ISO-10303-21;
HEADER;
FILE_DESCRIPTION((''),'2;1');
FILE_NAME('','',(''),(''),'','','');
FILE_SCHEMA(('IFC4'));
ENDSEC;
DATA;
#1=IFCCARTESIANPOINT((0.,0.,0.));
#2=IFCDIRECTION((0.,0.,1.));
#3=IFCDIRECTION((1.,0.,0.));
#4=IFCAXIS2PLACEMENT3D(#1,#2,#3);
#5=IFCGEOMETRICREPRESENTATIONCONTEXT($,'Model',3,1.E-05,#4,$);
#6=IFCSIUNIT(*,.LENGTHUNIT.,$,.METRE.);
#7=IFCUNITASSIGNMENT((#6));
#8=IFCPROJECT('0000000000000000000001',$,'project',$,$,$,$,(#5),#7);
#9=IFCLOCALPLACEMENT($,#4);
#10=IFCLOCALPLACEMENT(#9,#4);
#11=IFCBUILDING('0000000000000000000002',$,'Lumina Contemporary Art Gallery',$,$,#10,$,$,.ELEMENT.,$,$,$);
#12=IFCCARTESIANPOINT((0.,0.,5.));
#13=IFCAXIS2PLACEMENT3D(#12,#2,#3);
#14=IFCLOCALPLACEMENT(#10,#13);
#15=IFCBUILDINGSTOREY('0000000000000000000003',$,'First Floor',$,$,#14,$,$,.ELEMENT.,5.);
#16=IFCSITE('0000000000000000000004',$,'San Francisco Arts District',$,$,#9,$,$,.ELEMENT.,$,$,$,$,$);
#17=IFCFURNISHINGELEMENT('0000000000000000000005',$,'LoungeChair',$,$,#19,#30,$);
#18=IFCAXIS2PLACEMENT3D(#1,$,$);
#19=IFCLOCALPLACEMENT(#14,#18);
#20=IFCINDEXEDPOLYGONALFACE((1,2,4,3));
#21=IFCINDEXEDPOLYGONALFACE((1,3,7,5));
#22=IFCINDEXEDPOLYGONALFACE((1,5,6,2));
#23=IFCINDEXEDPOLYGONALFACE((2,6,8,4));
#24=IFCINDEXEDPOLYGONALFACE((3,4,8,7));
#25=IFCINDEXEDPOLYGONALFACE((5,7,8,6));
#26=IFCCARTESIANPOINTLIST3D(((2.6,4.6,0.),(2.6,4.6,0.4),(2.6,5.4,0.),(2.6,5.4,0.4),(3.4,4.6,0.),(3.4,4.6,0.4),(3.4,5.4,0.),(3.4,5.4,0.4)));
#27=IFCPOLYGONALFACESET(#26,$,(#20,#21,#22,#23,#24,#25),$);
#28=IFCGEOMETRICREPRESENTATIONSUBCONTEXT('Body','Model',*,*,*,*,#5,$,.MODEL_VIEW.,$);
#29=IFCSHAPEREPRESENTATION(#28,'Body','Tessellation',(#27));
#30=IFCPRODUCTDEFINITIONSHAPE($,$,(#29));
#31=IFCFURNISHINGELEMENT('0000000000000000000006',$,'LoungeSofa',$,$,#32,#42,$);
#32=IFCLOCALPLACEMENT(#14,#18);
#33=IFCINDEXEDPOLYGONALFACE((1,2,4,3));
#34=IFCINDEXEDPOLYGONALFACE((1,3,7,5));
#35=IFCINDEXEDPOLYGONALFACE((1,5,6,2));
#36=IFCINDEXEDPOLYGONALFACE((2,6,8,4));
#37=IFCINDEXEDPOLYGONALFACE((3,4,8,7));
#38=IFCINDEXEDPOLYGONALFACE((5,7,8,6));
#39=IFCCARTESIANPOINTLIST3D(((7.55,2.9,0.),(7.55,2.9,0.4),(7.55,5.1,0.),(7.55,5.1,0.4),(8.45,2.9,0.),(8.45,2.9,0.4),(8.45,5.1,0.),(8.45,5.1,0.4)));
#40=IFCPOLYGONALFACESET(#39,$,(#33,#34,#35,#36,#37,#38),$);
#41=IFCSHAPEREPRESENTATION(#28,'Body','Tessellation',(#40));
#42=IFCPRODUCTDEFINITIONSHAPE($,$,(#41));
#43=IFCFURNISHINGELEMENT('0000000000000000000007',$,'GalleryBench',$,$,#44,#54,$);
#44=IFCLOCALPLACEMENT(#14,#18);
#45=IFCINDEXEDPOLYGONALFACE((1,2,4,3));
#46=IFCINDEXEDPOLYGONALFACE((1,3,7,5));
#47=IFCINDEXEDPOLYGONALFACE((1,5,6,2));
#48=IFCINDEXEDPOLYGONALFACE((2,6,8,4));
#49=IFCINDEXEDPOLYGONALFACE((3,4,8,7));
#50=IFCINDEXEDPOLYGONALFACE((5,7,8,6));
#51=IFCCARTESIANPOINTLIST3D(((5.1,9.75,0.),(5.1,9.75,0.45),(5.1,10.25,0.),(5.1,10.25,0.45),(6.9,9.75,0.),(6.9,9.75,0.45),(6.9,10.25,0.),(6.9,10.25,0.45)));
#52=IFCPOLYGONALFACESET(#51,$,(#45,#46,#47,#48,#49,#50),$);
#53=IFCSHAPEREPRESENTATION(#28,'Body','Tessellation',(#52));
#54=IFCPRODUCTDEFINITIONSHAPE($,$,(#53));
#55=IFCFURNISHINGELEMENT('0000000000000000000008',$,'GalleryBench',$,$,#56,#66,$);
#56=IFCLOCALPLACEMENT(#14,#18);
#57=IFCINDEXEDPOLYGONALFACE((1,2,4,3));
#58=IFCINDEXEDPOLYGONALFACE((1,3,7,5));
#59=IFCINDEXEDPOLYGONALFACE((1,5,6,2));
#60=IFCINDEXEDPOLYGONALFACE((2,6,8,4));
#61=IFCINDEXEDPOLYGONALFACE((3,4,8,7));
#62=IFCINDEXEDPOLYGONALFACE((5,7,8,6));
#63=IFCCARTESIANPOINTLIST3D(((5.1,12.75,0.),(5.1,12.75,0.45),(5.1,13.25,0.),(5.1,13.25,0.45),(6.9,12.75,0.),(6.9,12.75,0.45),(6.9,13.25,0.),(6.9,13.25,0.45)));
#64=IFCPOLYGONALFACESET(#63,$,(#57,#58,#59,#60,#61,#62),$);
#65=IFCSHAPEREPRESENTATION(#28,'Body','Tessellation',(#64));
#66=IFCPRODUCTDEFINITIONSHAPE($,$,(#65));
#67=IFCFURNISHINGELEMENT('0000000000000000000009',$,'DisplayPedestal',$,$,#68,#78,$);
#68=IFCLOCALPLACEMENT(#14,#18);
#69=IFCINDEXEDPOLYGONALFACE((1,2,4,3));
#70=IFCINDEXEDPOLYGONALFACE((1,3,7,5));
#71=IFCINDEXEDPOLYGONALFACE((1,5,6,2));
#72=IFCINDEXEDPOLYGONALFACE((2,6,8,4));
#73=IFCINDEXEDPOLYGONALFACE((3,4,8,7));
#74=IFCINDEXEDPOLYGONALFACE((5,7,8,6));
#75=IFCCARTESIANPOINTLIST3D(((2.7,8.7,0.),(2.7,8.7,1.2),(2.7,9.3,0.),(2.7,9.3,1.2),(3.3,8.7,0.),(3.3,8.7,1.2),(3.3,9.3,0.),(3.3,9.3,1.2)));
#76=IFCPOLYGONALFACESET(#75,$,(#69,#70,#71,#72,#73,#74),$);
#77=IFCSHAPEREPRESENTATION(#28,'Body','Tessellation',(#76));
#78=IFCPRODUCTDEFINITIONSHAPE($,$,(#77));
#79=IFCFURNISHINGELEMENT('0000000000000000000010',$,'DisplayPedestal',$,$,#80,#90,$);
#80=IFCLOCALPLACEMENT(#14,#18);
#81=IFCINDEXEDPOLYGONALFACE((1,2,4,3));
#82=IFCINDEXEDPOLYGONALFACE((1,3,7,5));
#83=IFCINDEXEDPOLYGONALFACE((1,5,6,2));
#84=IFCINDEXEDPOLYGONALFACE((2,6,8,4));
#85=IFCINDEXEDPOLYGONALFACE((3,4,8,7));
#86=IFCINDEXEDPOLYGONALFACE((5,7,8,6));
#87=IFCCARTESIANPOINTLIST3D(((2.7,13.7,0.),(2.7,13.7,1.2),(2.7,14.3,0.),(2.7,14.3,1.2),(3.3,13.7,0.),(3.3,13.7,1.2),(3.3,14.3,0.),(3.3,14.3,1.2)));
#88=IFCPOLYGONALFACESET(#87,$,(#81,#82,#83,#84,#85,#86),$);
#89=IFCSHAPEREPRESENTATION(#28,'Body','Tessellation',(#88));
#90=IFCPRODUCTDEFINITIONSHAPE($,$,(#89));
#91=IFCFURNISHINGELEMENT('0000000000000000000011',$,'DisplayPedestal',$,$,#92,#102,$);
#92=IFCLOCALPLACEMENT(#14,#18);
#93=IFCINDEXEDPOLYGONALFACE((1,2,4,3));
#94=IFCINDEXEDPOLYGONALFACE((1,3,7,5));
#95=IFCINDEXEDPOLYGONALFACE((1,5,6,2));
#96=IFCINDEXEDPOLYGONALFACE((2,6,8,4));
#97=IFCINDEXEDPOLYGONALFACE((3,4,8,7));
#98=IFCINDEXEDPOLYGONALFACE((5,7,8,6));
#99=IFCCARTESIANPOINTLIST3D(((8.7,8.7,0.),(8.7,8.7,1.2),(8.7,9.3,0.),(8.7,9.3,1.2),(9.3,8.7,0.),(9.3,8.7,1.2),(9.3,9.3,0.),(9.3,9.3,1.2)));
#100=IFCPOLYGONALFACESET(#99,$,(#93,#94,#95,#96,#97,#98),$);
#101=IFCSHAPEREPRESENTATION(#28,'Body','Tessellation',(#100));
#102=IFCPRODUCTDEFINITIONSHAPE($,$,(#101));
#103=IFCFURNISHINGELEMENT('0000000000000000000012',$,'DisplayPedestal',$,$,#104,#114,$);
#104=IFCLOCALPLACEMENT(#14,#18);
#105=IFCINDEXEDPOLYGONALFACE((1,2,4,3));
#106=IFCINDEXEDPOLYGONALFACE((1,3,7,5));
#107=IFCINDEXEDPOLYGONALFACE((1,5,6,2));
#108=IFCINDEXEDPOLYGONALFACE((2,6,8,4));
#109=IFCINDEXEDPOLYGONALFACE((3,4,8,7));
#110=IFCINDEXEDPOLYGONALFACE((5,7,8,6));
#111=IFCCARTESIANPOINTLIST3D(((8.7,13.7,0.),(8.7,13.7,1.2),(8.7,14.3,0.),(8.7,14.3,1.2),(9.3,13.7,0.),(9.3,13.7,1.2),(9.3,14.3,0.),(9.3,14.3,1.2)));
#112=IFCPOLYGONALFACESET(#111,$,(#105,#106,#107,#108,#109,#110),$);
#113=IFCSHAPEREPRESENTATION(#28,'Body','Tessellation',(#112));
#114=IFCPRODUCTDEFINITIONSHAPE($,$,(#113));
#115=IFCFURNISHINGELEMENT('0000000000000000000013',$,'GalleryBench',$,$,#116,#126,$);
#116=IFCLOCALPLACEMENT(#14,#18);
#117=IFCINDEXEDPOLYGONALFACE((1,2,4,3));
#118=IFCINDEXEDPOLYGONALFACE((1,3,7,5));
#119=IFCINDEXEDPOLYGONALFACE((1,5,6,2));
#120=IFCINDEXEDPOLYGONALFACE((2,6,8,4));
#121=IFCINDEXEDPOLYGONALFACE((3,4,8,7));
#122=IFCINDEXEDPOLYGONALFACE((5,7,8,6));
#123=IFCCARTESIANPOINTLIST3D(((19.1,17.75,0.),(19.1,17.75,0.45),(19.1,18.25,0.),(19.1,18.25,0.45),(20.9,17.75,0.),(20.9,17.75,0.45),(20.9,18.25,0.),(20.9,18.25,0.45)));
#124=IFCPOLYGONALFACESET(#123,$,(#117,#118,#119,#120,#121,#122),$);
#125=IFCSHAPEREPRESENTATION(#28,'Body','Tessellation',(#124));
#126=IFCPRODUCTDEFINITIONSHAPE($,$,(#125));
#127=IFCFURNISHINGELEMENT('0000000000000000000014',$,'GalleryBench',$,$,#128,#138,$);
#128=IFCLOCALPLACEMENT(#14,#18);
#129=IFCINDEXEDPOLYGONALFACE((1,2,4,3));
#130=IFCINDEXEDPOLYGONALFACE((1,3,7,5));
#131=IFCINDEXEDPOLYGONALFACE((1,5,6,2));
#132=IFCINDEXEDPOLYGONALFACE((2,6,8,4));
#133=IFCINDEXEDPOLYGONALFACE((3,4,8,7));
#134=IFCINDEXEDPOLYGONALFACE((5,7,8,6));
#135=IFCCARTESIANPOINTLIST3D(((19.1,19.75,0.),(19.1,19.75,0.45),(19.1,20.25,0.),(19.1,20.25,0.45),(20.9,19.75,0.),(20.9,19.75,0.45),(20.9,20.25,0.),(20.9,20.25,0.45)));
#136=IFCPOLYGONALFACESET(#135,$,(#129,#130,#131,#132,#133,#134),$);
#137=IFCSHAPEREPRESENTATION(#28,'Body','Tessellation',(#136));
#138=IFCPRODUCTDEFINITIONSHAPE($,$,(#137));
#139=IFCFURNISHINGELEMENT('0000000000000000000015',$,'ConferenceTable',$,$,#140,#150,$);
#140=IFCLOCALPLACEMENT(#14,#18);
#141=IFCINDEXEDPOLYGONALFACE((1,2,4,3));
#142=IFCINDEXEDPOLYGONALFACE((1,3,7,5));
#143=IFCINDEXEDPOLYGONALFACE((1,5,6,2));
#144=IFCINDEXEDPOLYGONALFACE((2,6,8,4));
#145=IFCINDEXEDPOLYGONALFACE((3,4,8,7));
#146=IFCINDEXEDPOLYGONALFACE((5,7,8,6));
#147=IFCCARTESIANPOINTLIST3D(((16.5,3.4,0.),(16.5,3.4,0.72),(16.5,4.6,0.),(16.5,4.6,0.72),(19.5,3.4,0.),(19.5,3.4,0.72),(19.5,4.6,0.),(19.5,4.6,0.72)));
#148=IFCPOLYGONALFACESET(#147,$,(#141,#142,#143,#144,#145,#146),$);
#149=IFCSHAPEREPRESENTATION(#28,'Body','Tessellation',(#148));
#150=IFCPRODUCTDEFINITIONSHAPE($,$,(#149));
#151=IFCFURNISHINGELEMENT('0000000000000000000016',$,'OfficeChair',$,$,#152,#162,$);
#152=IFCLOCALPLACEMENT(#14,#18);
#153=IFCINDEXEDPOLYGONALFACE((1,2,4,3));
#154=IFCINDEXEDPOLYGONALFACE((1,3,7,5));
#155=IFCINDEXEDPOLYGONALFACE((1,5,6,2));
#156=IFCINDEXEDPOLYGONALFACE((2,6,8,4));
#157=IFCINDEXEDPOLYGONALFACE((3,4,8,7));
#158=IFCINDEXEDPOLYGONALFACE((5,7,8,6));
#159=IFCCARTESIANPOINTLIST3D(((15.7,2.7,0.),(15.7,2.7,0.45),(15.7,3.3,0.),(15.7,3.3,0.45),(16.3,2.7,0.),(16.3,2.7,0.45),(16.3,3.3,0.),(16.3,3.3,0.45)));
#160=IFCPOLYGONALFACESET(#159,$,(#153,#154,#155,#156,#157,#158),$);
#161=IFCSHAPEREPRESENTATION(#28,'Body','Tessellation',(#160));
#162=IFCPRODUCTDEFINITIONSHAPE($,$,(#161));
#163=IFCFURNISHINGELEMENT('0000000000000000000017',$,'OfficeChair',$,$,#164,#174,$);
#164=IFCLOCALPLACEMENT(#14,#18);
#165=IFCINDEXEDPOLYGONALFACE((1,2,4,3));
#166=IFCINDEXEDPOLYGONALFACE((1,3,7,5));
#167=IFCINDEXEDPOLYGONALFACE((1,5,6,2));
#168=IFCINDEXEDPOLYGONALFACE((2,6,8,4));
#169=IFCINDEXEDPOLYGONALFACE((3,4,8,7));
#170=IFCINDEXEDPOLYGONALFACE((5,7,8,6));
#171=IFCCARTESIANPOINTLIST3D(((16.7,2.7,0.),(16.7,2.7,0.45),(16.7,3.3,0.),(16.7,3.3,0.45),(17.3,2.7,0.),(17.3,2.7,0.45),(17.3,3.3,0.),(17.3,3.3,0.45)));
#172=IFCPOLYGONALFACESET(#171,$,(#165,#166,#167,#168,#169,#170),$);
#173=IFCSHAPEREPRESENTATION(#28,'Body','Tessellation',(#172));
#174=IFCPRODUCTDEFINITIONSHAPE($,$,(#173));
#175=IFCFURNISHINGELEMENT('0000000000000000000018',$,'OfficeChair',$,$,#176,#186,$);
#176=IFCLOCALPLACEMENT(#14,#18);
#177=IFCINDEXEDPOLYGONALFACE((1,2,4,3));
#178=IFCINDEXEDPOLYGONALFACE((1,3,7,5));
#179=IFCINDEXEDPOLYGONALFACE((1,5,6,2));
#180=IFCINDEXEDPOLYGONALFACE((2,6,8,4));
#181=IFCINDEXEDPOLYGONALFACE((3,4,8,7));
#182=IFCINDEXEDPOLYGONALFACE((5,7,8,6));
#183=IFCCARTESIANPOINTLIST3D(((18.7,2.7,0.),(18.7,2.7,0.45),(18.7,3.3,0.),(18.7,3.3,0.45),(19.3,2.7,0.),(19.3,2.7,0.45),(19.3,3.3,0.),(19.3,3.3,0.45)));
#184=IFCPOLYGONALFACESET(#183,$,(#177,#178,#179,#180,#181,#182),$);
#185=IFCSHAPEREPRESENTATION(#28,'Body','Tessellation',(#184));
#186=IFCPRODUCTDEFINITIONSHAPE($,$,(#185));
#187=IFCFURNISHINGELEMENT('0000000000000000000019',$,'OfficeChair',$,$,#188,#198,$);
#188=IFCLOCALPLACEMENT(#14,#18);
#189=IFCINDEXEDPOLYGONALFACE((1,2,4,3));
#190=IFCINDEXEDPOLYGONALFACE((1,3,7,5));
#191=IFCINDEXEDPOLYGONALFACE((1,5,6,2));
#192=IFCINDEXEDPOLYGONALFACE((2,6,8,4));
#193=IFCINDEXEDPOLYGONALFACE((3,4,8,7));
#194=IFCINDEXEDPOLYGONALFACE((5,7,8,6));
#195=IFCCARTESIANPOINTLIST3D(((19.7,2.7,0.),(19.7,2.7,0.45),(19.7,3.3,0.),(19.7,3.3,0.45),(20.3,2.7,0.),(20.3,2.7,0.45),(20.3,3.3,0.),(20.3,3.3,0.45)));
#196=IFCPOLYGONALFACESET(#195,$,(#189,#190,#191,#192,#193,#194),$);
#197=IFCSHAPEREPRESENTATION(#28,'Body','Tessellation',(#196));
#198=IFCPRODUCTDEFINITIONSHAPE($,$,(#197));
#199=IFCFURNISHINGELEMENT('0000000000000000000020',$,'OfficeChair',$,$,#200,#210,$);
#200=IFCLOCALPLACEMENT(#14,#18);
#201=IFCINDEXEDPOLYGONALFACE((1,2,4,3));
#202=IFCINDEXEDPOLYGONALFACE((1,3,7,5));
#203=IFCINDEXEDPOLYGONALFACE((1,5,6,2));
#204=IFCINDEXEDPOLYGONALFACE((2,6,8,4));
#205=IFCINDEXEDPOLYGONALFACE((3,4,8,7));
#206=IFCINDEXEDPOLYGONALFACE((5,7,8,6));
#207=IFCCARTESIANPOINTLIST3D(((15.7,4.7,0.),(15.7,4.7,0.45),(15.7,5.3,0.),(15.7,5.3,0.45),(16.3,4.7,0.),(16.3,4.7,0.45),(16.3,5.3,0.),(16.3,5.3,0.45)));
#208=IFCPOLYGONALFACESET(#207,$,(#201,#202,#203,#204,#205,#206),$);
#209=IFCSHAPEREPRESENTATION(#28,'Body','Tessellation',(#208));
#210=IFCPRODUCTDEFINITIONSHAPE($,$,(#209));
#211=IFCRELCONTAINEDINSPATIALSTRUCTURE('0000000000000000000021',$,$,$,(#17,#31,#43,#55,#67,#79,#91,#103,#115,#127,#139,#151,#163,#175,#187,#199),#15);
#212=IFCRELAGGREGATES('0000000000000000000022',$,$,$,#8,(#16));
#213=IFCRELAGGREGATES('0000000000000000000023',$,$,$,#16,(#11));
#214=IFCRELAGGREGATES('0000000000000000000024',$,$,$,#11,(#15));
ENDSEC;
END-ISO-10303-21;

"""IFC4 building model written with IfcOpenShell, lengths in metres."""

from ifc_helpers import new_model, si_unit, frame, origin_with_axes, place, context, subcontext, project, spatial, polyline, outline, extrude, element, save


model = new_model("IFC4")

# Units and contexts
model_context = context("Model", 3, precision=1e-05, world=origin_with_axes())
body_context = subcontext(model_context, "Body", "Model", "MODEL_VIEW")
ifc_project = project(units=[si_unit("LENGTHUNIT", "METRE")], contexts=[model_context])

# Site, building, storey
site_placement = place(None, origin_with_axes())
site = spatial("IfcSite", under=ifc_project, at=site_placement, Name="San Francisco Arts District", CompositionType="ELEMENT")
building_placement = place(site_placement, origin_with_axes())
building = spatial("IfcBuilding", under=site, at=building_placement, Name="Lumina Contemporary Art Gallery", CompositionType="ELEMENT")
storey_placement = place(building_placement, frame((0.0, 0.0, 5.0), z_axis=(0.0, 0.0, 1.0), x_axis=(1.0, 0.0, 0.0)))
storey = spatial("IfcBuildingStorey", under=building, at=storey_placement, Name="First Floor", CompositionType="ELEMENT", Elevation=5.0)

# Furnishing elements
furnishing_1_placement = place(storey_placement, origin_with_axes())
element("IfcFurnishingElement", 1, at=furnishing_1_placement, inside=storey, Name="LoungeChair", context=body_context, shape_type="SweptSolid", body=[
    extrude(outline(polyline([(2.6, 5.4, 0.0), (2.6, 4.6, 0.0), (3.4, 4.6, 0.0), (3.4, 5.4, 0.0), (2.6, 5.4, 0.0)])), None, (0.0, 0.0, 1.0), 0.4),
])
furnishing_2_placement = place(storey_placement, origin_with_axes())
element("IfcFurnishingElement", 2, at=furnishing_2_placement, inside=storey, Name="LoungeSofa", context=body_context, shape_type="SweptSolid", body=[
    extrude(outline(polyline([(8.45, 2.9, 0.0), (8.45, 5.1, 0.0), (7.55, 5.1, 0.0), (7.55, 2.9, 0.0), (8.45, 2.9, 0.0)])), None, (0.0, 0.0, 1.0), 0.4),
])
furnishing_3_placement = place(storey_placement, origin_with_axes())
element("IfcFurnishingElement", 3, at=furnishing_3_placement, inside=storey, Name="GalleryBench", context=body_context, shape_type="SweptSolid", body=[
    extrude(outline(polyline([(6.9, 10.25, 0.0), (5.1, 10.25, 0.0), (5.1, 9.75, 0.0), (6.9, 9.75, 0.0), (6.9, 10.25, 0.0)])), None, (0.0, 0.0, 1.0), 0.45),
])
furnishing_4_placement = place(storey_placement, origin_with_axes())
element("IfcFurnishingElement", 4, at=furnishing_4_placement, inside=storey, Name="GalleryBench", context=body_context, shape_type="SweptSolid", body=[
    extrude(outline(polyline([(5.1, 12.75, 0.0), (6.9, 12.75, 0.0), (6.9, 13.25, 0.0), (5.1, 13.25, 0.0), (5.1, 12.75, 0.0)])), None, (0.0, 0.0, 1.0), 0.45),
])
furnishing_5_placement = place(storey_placement, origin_with_axes())
element("IfcFurnishingElement", 5, at=furnishing_5_placement, inside=storey, Name="DisplayPedestal", context=body_context, shape_type="SweptSolid", body=[
    extrude(outline(polyline([(2.7, 9.3, 0.0), (2.7, 8.7, 0.0), (3.3, 8.7, 0.0), (3.3, 9.3, 0.0), (2.7, 9.3, 0.0)])), None, (0.0, 0.0, 1.0), 1.2),
])
furnishing_6_placement = place(storey_placement, origin_with_axes())
element("IfcFurnishingElement", 6, at=furnishing_6_placement, inside=storey, Name="DisplayPedestal", context=body_context, shape_type="SweptSolid", body=[
    extrude(outline(polyline([(2.7, 14.3, 0.0), (2.7, 13.7, 0.0), (3.3, 13.7, 0.0), (3.3, 14.3, 0.0), (2.7, 14.3, 0.0)])), None, (0.0, 0.0, 1.0), 1.2),
])
furnishing_7_placement = place(storey_placement, origin_with_axes())
element("IfcFurnishingElement", 7, at=furnishing_7_placement, inside=storey, Name="DisplayPedestal", context=body_context, shape_type="SweptSolid", body=[
    extrude(outline(polyline([(9.3, 8.7, 0.0), (9.3, 9.3, 0.0), (8.7, 9.3, 0.0), (8.7, 8.7, 0.0), (9.3, 8.7, 0.0)])), None, (0.0, 0.0, 1.0), 1.2),
])
furnishing_8_placement = place(storey_placement, origin_with_axes())
element("IfcFurnishingElement", 8, at=furnishing_8_placement, inside=storey, Name="DisplayPedestal", context=body_context, shape_type="SweptSolid", body=[
    extrude(outline(polyline([(9.3, 13.7, 0.0), (9.3, 14.3, 0.0), (8.7, 14.3, 0.0), (8.7, 13.7, 0.0), (9.3, 13.7, 0.0)])), None, (0.0, 0.0, 1.0), 1.2),
])
furnishing_9_placement = place(storey_placement, origin_with_axes())
element("IfcFurnishingElement", 9, at=furnishing_9_placement, inside=storey, Name="GalleryBench", context=body_context, shape_type="SweptSolid", body=[
    extrude(outline(polyline([(20.9, 18.25, 0.0), (19.1, 18.25, 0.0), (19.1, 17.75, 0.0), (20.9, 17.75, 0.0), (20.9, 18.25, 0.0)])), None, (0.0, 0.0, 1.0), 0.45),
])
furnishing_10_placement = place(storey_placement, origin_with_axes())
element("IfcFurnishingElement", 10, at=furnishing_10_placement, inside=storey, Name="GalleryBench", context=body_context, shape_type="SweptSolid", body=[
    extrude(outline(polyline([(19.1, 19.75, 0.0), (20.9, 19.75, 0.0), (20.9, 20.25, 0.0), (19.1, 20.25, 0.0), (19.1, 19.75, 0.0)])), None, (0.0, 0.0, 1.0), 0.45),
])
furnishing_11_placement = place(storey_placement, origin_with_axes())
element("IfcFurnishingElement", 11, at=furnishing_11_placement, inside=storey, Name="ConferenceTable", context=body_context, shape_type="SweptSolid", body=[
    extrude(outline(polyline([(16.5, 3.4, 0.0), (19.5, 3.4, 0.0), (19.5, 4.6, 0.0), (16.5, 4.6, 0.0), (16.5, 3.4, 0.0)])), None, (0.0, 0.0, 1.0), 0.72),
])
furnishing_12_placement = place(storey_placement, origin_with_axes())
element("IfcFurnishingElement", 12, at=furnishing_12_placement, inside=storey, Name="OfficeChair", context=body_context, shape_type="SweptSolid", body=[
    extrude(outline(polyline([(15.7, 2.7, 0.0), (16.3, 2.7, 0.0), (16.3, 3.3, 0.0), (15.7, 3.3, 0.0), (15.7, 2.7, 0.0)])), None, (0.0, 0.0, 1.0), 0.45),
])
furnishing_13_placement = place(storey_placement, origin_with_axes())
element("IfcFurnishingElement", 13, at=furnishing_13_placement, inside=storey, Name="OfficeChair", context=body_context, shape_type="SweptSolid", body=[
    extrude(outline(polyline([(16.7, 2.7, 0.0), (17.3, 2.7, 0.0), (17.3, 3.3, 0.0), (16.7, 3.3, 0.0), (16.7, 2.7, 0.0)])), None, (0.0, 0.0, 1.0), 0.45),
])
furnishing_14_placement = place(storey_placement, origin_with_axes())
element("IfcFurnishingElement", 14, at=furnishing_14_placement, inside=storey, Name="OfficeChair", context=body_context, shape_type="SweptSolid", body=[
    extrude(outline(polyline([(18.7, 2.7, 0.0), (19.3, 2.7, 0.0), (19.3, 3.3, 0.0), (18.7, 3.3, 0.0), (18.7, 2.7, 0.0)])), None, (0.0, 0.0, 1.0), 0.45),
])
furnishing_15_placement = place(storey_placement, origin_with_axes())
element("IfcFurnishingElement", 15, at=furnishing_15_placement, inside=storey, Name="OfficeChair", context=body_context, shape_type="SweptSolid", body=[
    extrude(outline(polyline([(19.7, 2.7, 0.0), (20.3, 2.7, 0.0), (20.3, 3.3, 0.0), (19.7, 3.3, 0.0), (19.7, 2.7, 0.0)])), None, (0.0, 0.0, 1.0), 0.45),
])
furnishing_16_placement = place(storey_placement, origin_with_axes())
element("IfcFurnishingElement", 16, at=furnishing_16_placement, inside=storey, Name="OfficeChair", context=body_context, shape_type="SweptSolid", body=[
    extrude(outline(polyline([(16.3, 5.3, 0.0), (15.7, 5.3, 0.0), (15.7, 4.7, 0.0), (16.3, 4.7, 0.0), (16.3, 5.3, 0.0)])), None, (0.0, 0.0, 1.0), 0.45),
])

save(model, "model.ifc")
